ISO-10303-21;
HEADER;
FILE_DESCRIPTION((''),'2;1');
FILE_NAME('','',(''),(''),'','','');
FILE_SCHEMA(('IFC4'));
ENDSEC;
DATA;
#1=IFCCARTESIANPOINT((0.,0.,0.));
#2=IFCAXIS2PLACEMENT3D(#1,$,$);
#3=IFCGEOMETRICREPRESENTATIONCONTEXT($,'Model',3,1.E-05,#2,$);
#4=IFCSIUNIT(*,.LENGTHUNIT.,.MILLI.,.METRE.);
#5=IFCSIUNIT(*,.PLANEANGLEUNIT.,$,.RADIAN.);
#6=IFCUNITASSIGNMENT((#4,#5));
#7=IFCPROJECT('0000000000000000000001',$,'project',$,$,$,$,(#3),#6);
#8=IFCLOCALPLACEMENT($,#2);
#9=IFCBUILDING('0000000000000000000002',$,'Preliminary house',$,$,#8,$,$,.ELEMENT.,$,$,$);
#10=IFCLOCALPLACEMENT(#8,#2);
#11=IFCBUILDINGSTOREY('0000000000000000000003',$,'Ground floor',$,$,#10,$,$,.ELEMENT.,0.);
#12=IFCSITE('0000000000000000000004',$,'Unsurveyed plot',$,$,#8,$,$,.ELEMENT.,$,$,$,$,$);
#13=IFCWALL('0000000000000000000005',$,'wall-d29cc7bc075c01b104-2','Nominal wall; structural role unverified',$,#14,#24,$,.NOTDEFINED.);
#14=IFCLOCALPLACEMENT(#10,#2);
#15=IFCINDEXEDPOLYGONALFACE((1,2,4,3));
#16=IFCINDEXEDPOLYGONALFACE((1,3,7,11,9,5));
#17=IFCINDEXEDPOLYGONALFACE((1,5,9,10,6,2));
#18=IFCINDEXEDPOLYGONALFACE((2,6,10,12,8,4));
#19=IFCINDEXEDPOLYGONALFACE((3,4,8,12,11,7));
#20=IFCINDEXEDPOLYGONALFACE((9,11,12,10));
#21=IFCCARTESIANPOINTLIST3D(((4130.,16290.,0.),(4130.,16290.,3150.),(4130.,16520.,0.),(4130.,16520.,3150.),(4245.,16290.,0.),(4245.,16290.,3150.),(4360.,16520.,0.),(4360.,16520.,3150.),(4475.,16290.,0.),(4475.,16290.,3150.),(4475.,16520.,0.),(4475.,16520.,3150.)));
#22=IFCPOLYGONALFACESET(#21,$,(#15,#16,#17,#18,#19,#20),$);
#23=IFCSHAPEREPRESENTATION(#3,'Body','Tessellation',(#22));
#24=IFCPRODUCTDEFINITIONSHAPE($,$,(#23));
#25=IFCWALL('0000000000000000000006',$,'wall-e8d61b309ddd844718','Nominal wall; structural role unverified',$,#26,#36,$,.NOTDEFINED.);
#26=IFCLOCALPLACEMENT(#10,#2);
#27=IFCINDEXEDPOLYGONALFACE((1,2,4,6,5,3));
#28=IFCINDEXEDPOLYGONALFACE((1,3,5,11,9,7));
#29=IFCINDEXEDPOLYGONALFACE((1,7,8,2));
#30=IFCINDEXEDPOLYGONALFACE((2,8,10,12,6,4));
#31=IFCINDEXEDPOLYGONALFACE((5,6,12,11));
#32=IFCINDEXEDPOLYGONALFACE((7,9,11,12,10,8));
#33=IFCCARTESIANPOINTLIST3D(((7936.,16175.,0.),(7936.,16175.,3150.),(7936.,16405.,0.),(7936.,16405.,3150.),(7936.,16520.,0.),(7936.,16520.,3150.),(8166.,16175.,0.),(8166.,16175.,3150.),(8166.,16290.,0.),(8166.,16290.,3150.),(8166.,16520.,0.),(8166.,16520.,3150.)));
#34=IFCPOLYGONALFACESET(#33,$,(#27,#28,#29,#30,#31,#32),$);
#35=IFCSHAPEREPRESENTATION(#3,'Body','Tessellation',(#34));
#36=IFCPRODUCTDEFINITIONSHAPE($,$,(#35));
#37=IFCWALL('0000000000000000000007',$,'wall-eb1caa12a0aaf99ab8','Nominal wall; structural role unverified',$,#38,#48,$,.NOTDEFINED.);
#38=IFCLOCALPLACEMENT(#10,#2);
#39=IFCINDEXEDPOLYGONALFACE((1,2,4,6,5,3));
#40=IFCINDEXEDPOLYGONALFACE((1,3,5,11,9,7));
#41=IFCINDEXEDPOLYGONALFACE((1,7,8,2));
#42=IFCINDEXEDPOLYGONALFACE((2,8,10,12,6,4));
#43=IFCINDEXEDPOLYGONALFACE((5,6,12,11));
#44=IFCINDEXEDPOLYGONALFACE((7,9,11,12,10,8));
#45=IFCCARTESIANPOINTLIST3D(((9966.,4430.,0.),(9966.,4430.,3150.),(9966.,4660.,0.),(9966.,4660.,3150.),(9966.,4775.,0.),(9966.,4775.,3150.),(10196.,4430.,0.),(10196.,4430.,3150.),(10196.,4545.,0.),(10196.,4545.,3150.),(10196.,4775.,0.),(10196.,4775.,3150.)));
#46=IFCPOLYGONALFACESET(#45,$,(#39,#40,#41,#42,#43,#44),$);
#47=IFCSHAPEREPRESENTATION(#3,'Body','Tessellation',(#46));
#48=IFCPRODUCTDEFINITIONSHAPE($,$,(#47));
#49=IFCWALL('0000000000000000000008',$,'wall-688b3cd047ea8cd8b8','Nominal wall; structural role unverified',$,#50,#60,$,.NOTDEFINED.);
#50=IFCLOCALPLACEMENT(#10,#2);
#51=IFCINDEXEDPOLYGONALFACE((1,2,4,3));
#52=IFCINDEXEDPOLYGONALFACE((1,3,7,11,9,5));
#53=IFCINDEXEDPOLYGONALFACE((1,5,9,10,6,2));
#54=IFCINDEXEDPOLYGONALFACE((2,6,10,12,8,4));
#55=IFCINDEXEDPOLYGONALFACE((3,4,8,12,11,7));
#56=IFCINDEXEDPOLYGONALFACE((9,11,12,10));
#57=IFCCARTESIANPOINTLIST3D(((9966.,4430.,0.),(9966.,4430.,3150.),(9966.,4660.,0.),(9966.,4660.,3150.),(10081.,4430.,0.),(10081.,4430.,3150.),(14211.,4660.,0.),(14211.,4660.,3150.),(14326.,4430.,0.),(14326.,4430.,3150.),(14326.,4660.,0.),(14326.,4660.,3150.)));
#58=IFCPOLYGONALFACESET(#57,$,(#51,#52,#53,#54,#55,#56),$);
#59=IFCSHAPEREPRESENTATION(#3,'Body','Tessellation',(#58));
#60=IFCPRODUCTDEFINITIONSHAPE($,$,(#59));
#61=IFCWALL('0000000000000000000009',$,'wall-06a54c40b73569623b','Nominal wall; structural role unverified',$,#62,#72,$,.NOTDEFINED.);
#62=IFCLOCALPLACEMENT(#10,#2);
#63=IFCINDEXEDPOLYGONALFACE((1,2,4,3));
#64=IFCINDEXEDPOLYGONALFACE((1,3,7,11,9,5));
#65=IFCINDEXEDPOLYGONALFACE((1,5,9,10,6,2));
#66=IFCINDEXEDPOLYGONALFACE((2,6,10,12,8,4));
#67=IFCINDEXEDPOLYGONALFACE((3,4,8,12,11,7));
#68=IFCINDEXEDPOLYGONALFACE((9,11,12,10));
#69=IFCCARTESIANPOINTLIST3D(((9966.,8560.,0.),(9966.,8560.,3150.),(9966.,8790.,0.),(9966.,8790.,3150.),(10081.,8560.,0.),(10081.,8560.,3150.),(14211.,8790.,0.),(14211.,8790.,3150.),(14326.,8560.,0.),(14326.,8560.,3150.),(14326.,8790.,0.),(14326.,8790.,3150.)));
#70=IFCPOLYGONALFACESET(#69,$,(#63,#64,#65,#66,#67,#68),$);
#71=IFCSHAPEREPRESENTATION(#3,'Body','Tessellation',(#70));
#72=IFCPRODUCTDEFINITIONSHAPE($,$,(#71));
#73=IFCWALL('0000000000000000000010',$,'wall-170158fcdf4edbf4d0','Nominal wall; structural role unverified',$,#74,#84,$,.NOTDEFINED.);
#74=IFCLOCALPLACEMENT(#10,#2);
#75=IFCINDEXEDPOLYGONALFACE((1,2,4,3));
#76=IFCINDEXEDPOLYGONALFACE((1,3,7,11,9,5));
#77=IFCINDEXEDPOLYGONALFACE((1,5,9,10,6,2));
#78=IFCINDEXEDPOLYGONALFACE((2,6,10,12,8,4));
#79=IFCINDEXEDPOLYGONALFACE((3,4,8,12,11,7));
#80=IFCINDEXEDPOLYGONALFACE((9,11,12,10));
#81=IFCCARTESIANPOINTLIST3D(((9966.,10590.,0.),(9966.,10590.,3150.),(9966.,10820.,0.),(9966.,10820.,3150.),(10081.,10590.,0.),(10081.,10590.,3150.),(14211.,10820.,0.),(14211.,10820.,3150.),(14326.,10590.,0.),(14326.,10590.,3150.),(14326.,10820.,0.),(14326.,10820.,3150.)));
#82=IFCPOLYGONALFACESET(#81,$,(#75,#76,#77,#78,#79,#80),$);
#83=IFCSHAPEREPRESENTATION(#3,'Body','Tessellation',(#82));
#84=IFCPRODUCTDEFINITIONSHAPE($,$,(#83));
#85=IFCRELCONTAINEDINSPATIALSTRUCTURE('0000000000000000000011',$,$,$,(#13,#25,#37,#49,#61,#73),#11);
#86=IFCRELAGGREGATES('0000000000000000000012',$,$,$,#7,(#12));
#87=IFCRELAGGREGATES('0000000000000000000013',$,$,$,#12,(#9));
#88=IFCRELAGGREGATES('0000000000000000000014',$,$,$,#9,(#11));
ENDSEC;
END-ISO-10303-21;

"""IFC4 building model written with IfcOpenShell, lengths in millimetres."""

from ifc_helpers import new_model, si_unit, origin, place, context, project, spatial, polyline, outline, extrude, element, save


model = new_model("IFC4")

# Units and contexts
model_context = context("Model", 3, precision=1e-05, world=origin())
ifc_project = project(units=[si_unit("LENGTHUNIT", "METRE", prefix="MILLI"), si_unit("PLANEANGLEUNIT", "RADIAN")], contexts=[model_context])

# Site, building, storey
placement_1 = place(None, origin())
site = spatial("IfcSite", under=ifc_project, at=placement_1, Name="Unsurveyed plot", CompositionType="ELEMENT")
building = spatial("IfcBuilding", under=site, at=placement_1, Name="Preliminary house", CompositionType="ELEMENT")
placement_2 = place(placement_1, origin())
storey = spatial("IfcBuildingStorey", under=building, at=placement_2, Name="Ground floor", CompositionType="ELEMENT", Elevation=0.0)

# Wall
element("IfcWall", 1, at=placement_2, inside=storey, Name="wall-d29cc7bc075c01b104-2", Description="Nominal wall; structural role unverified", PredefinedType="NOTDEFINED", context=model_context, shape_type="SweptSolid", body=[
    extrude(outline(polyline([(4360.0, 16520.0), (4475.0, 16520.0), (4475.0, 16290.0), (4245.0, 16290.0), (4130.0, 16290.0), (4130.0, 16520.0), (4360.0, 16520.0)])), origin(), (0.0, 0.0, 1.0), 3150.0),
])

# Wall
element("IfcWall", 2, at=placement_2, inside=storey, Name="wall-e8d61b309ddd844718", Description="Nominal wall; structural role unverified", PredefinedType="NOTDEFINED", context=model_context, shape_type="SweptSolid", body=[
    extrude(outline(polyline([(7936.0, 16405.0), (7936.0, 16520.0), (8166.0, 16520.0), (8166.0, 16290.0), (8166.0, 16175.0), (7936.0, 16175.0), (7936.0, 16405.0)])), origin(), (0.0, 0.0, 1.0), 3150.0),
])

# Wall
element("IfcWall", 3, at=placement_2, inside=storey, Name="wall-eb1caa12a0aaf99ab8", Description="Nominal wall; structural role unverified", PredefinedType="NOTDEFINED", context=model_context, shape_type="SweptSolid", body=[
    extrude(outline(polyline([(9966.0, 4660.0), (9966.0, 4775.0), (10196.0, 4775.0), (10196.0, 4545.0), (10196.0, 4430.0), (9966.0, 4430.0), (9966.0, 4660.0)])), origin(), (0.0, 0.0, 1.0), 3150.0),
])

# Wall
element("IfcWall", 4, at=placement_2, inside=storey, Name="wall-688b3cd047ea8cd8b8", Description="Nominal wall; structural role unverified", PredefinedType="NOTDEFINED", context=model_context, shape_type="SweptSolid", body=[
    extrude(outline(polyline([(14211.0, 4660.0), (14326.0, 4660.0), (14326.0, 4430.0), (10081.0, 4430.0), (9966.0, 4430.0), (9966.0, 4660.0), (14211.0, 4660.0)])), origin(), (0.0, 0.0, 1.0), 3150.0),
])

# Wall
element("IfcWall", 5, at=placement_2, inside=storey, Name="wall-06a54c40b73569623b", Description="Nominal wall; structural role unverified", PredefinedType="NOTDEFINED", context=model_context, shape_type="SweptSolid", body=[
    extrude(outline(polyline([(14211.0, 8790.0), (14326.0, 8790.0), (14326.0, 8560.0), (10081.0, 8560.0), (9966.0, 8560.0), (9966.0, 8790.0), (14211.0, 8790.0)])), origin(), (0.0, 0.0, 1.0), 3150.0),
])

# Wall
element("IfcWall", 6, at=placement_2, inside=storey, Name="wall-170158fcdf4edbf4d0", Description="Nominal wall; structural role unverified", PredefinedType="NOTDEFINED", context=model_context, shape_type="SweptSolid", body=[
    extrude(outline(polyline([(14211.0, 10820.0), (14326.0, 10820.0), (14326.0, 10590.0), (10081.0, 10590.0), (9966.0, 10590.0), (9966.0, 10820.0), (14211.0, 10820.0)])), origin(), (0.0, 0.0, 1.0), 3150.0),
])

save(model, "model.ifc")
